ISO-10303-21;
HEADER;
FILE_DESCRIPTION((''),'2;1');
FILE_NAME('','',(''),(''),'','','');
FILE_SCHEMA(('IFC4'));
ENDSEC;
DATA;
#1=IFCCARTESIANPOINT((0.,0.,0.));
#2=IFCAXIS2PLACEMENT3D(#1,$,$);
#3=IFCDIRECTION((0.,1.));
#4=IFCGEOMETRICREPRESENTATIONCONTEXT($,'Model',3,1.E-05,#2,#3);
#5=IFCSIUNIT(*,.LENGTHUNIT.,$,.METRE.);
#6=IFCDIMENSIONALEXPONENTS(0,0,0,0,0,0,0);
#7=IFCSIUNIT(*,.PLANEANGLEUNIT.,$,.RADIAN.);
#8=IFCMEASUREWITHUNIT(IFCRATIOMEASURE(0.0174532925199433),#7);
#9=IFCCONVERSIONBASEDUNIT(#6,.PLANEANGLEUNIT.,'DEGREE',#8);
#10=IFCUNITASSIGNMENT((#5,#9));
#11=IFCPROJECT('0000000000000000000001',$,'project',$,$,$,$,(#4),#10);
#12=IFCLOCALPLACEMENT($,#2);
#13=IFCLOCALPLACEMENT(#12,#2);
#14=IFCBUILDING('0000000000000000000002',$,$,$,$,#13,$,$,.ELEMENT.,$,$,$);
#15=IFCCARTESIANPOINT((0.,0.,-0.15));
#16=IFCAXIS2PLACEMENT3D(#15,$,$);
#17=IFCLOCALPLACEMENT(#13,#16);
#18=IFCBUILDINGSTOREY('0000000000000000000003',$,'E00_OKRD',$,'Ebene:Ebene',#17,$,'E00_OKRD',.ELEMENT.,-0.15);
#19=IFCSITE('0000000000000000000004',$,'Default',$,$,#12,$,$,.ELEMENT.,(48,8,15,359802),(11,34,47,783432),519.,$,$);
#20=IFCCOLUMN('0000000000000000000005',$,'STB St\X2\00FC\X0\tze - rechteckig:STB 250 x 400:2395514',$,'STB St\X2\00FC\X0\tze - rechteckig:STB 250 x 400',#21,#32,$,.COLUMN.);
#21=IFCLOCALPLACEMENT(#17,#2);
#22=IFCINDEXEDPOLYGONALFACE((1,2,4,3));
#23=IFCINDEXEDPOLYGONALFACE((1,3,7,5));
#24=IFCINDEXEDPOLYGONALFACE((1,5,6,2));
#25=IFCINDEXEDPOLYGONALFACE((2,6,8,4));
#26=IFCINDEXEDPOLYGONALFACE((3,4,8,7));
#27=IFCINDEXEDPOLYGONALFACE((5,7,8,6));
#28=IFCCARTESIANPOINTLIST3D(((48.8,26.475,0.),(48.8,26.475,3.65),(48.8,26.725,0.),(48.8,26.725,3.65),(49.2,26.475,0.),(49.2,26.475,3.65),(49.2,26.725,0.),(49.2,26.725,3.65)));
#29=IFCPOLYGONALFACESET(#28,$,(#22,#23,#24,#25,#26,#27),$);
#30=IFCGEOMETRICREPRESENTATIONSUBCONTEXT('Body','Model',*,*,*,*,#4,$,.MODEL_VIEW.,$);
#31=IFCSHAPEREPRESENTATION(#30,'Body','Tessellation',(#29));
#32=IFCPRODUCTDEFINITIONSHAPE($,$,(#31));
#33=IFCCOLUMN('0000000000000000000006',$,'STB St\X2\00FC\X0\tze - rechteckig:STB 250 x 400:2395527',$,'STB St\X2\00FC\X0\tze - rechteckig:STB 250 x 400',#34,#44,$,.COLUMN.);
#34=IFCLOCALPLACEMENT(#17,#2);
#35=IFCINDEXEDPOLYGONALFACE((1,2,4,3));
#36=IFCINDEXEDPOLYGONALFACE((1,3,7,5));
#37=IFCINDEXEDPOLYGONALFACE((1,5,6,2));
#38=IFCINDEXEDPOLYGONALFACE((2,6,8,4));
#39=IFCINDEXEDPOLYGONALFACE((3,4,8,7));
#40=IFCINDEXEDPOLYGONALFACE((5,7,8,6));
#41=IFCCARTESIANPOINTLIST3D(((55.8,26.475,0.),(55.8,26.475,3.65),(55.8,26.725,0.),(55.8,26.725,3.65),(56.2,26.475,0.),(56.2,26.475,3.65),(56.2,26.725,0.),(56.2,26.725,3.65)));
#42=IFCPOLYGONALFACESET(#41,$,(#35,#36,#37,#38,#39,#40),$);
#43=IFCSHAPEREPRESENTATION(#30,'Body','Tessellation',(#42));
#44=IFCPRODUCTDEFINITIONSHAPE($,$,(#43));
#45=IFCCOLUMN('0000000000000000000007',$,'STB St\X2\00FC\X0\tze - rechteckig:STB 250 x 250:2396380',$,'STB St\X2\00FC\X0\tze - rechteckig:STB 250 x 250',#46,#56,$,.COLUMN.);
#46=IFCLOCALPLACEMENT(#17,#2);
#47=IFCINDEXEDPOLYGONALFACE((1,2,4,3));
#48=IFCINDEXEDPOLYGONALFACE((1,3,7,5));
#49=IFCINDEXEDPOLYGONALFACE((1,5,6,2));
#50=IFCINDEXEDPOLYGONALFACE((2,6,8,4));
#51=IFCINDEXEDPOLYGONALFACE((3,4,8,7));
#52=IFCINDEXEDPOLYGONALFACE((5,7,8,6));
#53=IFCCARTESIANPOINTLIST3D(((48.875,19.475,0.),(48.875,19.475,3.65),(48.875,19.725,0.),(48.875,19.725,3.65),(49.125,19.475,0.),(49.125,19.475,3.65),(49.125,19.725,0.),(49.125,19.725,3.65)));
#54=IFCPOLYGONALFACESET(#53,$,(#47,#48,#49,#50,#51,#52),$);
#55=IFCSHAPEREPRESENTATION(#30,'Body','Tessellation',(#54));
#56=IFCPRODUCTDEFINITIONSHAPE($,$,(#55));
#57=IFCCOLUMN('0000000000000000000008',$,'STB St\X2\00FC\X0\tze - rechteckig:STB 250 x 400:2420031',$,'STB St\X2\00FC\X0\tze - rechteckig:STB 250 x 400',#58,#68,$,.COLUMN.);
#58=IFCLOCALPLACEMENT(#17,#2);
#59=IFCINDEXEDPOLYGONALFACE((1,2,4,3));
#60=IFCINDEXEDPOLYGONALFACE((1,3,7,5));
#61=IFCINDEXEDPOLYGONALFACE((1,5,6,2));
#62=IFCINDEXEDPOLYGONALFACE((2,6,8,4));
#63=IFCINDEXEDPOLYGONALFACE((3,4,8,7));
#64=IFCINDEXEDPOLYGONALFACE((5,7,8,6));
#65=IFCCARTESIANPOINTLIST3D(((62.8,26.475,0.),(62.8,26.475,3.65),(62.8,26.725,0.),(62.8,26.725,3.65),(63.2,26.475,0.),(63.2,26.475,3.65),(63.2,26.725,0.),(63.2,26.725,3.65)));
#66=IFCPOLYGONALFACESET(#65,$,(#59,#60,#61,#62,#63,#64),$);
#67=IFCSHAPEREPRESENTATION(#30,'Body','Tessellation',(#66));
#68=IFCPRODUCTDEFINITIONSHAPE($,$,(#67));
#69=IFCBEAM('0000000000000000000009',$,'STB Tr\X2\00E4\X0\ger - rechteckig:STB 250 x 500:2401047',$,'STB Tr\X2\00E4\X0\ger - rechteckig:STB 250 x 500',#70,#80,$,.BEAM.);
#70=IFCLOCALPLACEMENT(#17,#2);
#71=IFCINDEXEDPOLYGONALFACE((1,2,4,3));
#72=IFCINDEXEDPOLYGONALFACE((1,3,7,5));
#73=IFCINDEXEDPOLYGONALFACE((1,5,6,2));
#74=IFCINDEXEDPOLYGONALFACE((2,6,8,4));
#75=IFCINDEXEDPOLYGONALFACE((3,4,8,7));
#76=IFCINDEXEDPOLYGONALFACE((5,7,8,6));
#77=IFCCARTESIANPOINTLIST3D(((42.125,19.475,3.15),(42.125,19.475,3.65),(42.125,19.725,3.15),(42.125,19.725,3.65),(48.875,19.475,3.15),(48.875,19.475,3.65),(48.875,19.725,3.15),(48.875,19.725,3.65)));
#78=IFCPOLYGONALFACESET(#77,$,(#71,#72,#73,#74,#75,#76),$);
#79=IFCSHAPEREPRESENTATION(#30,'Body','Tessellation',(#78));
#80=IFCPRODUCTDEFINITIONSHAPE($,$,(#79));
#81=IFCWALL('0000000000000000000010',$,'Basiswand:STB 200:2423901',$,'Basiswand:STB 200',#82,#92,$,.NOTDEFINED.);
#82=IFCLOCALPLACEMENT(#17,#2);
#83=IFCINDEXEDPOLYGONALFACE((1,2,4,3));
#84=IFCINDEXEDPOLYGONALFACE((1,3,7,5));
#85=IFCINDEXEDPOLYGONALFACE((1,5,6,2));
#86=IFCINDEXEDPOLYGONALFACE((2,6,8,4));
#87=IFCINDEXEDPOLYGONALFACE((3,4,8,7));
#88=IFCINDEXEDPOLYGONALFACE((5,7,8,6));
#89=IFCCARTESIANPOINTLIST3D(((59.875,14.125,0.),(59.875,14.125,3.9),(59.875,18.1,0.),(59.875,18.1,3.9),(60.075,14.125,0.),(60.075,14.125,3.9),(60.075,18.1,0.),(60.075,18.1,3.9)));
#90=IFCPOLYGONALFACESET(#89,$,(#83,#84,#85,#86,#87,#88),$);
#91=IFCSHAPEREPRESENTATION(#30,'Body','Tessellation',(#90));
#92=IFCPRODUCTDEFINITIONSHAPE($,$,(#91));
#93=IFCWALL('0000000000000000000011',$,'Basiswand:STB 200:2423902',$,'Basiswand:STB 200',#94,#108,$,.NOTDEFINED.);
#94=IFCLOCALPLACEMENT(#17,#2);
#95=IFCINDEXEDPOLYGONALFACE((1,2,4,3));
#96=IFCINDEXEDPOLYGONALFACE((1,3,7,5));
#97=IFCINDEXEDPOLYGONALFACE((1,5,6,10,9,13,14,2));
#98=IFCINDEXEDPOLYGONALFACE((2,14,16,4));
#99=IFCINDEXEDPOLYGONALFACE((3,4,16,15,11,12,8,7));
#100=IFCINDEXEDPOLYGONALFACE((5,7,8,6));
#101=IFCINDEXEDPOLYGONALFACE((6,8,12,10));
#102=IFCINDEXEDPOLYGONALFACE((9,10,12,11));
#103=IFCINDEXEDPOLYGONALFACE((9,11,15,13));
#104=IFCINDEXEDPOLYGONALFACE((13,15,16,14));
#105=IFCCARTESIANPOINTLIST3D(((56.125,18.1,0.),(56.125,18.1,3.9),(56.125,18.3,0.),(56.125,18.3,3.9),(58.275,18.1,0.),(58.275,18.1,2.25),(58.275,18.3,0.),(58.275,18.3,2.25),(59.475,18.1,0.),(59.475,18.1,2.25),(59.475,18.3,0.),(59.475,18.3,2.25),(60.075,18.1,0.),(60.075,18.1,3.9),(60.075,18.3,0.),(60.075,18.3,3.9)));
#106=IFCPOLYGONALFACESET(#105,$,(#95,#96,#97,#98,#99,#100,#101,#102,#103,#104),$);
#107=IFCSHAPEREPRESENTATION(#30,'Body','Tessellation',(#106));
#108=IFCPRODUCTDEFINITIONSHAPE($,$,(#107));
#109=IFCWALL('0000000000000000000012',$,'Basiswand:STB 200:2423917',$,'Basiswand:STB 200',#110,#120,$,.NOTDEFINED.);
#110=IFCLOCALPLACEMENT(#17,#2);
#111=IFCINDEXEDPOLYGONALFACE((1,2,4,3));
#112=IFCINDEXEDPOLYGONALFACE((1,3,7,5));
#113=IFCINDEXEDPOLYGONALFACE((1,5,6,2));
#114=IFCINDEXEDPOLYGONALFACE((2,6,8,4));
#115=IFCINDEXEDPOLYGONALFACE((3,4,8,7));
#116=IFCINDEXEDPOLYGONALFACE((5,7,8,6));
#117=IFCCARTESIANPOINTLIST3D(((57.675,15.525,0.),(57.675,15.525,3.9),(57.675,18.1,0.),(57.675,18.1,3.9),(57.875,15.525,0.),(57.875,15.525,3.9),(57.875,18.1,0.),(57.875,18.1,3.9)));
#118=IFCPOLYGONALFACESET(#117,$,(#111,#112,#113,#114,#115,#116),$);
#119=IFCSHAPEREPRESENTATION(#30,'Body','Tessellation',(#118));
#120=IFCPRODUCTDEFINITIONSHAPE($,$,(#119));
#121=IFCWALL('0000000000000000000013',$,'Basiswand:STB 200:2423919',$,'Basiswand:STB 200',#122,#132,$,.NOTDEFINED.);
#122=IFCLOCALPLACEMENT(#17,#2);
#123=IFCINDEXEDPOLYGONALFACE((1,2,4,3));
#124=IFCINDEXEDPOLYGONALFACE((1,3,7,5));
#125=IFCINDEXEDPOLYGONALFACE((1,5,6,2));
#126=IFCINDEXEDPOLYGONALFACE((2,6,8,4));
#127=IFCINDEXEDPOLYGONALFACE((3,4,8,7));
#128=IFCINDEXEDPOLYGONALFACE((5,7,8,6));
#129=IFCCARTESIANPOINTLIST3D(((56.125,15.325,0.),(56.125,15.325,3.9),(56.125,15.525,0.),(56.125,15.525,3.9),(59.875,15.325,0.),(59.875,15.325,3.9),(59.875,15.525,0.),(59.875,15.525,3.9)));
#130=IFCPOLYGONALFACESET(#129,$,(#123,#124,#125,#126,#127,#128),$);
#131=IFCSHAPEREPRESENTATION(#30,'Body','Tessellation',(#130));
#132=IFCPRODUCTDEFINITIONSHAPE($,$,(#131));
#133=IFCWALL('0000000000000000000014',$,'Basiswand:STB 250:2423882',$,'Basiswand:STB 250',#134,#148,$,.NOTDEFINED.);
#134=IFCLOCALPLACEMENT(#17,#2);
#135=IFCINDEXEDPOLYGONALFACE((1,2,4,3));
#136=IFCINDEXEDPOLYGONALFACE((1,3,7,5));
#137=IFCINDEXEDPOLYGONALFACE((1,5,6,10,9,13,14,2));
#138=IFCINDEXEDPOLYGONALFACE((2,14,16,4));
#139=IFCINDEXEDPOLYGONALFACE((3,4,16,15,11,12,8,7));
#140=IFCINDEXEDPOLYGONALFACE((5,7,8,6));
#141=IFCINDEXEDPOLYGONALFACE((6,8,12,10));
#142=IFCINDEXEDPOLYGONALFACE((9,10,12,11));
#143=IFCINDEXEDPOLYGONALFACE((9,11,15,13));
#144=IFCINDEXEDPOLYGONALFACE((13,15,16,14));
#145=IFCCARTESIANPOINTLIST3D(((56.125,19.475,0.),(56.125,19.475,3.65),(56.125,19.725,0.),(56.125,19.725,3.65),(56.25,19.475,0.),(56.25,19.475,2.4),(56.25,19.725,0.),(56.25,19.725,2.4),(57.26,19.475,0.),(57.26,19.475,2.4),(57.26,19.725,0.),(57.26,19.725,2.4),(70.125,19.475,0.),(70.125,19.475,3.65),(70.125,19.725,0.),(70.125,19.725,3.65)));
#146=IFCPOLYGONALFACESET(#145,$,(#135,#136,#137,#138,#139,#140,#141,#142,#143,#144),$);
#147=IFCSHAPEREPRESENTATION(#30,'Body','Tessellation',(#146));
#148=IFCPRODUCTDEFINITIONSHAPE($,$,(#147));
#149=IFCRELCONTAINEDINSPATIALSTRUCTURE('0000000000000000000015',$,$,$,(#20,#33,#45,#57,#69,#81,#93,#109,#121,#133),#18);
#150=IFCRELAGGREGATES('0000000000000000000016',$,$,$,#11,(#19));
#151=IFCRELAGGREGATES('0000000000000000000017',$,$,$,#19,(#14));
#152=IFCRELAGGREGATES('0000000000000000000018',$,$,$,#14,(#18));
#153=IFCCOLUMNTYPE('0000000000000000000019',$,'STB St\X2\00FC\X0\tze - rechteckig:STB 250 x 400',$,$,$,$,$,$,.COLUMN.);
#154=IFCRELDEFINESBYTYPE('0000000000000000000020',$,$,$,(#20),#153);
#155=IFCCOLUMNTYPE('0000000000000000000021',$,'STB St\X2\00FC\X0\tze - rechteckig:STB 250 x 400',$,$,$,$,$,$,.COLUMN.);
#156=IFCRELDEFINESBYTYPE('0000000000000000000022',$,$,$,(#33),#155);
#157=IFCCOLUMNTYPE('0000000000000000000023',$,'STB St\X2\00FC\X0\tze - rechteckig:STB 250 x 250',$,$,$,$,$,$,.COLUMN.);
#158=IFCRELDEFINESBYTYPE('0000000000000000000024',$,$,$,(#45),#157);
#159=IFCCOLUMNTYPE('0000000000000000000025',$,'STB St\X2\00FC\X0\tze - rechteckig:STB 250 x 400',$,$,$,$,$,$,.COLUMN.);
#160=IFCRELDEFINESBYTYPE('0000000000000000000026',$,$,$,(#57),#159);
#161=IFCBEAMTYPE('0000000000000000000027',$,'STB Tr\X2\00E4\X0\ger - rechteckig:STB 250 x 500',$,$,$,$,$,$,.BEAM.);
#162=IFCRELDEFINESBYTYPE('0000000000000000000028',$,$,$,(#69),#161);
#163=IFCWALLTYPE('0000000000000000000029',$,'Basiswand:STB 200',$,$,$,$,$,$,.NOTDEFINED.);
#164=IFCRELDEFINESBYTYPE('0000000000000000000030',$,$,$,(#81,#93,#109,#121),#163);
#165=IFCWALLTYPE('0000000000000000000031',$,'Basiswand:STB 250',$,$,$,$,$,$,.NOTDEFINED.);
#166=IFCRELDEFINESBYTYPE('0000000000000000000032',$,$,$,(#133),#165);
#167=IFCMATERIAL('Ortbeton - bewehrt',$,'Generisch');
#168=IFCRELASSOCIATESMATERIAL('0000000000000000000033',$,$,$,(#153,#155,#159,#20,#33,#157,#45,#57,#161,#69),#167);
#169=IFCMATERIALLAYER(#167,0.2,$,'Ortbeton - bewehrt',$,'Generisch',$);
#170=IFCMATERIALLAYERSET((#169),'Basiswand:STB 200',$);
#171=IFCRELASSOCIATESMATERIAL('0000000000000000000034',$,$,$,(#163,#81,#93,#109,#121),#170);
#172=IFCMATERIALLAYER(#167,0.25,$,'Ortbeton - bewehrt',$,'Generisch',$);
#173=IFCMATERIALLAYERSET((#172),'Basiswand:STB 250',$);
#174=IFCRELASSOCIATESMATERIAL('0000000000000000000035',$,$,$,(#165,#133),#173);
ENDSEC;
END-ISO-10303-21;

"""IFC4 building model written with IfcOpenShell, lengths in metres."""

from ifc_helpers import new_model, entity, si_unit, converted_unit, direction, frame, frame_2d, origin, origin_2d_with_axis, place, context, subcontext, project, spatial, rectangle, extrude, source, transform, mapped, material, layer, layer_set, layer_usage, material_profile, profile_set, profile_usage, type_object, type_shapes, element, save


model = new_model("IFC4")

# Units and contexts
model_context = context("Model", 3, precision=1e-05, world=origin(), true_north=direction((0.0, 1.0)))
body_context = subcontext(model_context, "Body", "Model", "MODEL_VIEW")
ifc_project = project(units=[si_unit("LENGTHUNIT", "METRE"), converted_unit("PLANEANGLEUNIT", "DEGREE", entity("IfcRatioMeasure", 0.0174532925199433), si_unit("PLANEANGLEUNIT", "RADIAN"), dimensions=[0, 0, 0, 0, 0, 0, 0])], contexts=[model_context])

# Site, building, storey
site_placement = place(None, frame((0.0, 0.0, 0.0)))
site = spatial("IfcSite", under=ifc_project, at=site_placement, Name="Default", CompositionType="ELEMENT", RefLatitude=(48, 8, 15, 359802), RefLongitude=(11, 34, 47, 783432), RefElevation=519.0)
building_placement = place(site_placement, origin())
building = spatial("IfcBuilding", under=site, at=building_placement, CompositionType="ELEMENT")
storey_placement = place(building_placement, frame((0.0, 0.0, -0.15)))
storey = spatial("IfcBuildingStorey", under=building, at=storey_placement, Name="E00_OKRD", ObjectType="Ebene:Ebene", LongName="E00_OKRD", CompositionType="ELEMENT", Elevation=-0.15)

# Columns
ifc_material_1 = material(Name="Ortbeton - bewehrt", Category="Generisch")
ifc_material_profile_1 = material_profile(ifc_material_1, rectangle(XDim=0.4, YDim=0.25, at=frame_2d((0.0, 0.0), x_axis=(1.0, 0.0))), Name="STB 250 x 400")
ifc_profile_set_1 = profile_set([ifc_material_profile_1], Name="STB 250 x 400")
ifc_profile_usage_1 = profile_usage(ifc_profile_set_1)
column_type_1 = type_object("IfcColumnType", Name="STB Stütze - rechteckig:STB 250 x 400", PredefinedType="COLUMN", material=ifc_profile_set_1)
shared_shape_1 = source(origin(), body_context, "Body", "SweptSolid", [
    extrude(rectangle(XDim=0.4, YDim=0.25, at=origin_2d_with_axis()), frame((0.2, 0.125, 0.0), z_axis=(0.0, 0.0, 1.0), x_axis=(-1.0, 0.0, 0.0)), (0.0, 0.0, 1.0), 3.65),
])
type_shapes(column_type_1, [shared_shape_1])
column_1_placement = place(storey_placement, frame((48.8, 26.475, 0.0)))
element("IfcColumn", 1, at=column_1_placement, inside=storey, type_object=column_type_1, material=ifc_profile_usage_1, Name="STB Stütze - rechteckig:STB 250 x 400:2395514", ObjectType="STB Stütze - rechteckig:STB 250 x 400", PredefinedType="COLUMN", context=body_context, shape_type="MappedRepresentation", body=[
    mapped(shared_shape_1, transform((0.0, 0.0, 0.0), scale=1.0)),
])
ifc_profile_usage_2 = profile_usage(ifc_profile_set_1)
column_type_2 = type_object("IfcColumnType", Name="STB Stütze - rechteckig:STB 250 x 400", PredefinedType="COLUMN", material=ifc_profile_set_1)
shared_shape_2 = source(origin(), body_context, "Body", "SweptSolid", [
    extrude(rectangle(XDim=0.4, YDim=0.25, at=frame_2d((0.0, 0.0), x_axis=(1.0, 0.0))), frame((0.2, 0.125, 0.0), z_axis=(0.0, 0.0, 1.0), x_axis=(-1.0, 0.0, 0.0)), (0.0, 0.0, 1.0), 3.65),
])
type_shapes(column_type_2, [shared_shape_2])
column_2_placement = place(storey_placement, frame((55.8, 26.475, 0.0)))
element("IfcColumn", 2, at=column_2_placement, inside=storey, type_object=column_type_2, material=ifc_profile_usage_2, Name="STB Stütze - rechteckig:STB 250 x 400:2395527", ObjectType="STB Stütze - rechteckig:STB 250 x 400", PredefinedType="COLUMN", context=body_context, shape_type="MappedRepresentation", body=[
    mapped(shared_shape_2, transform((0.0, 0.0, 0.0), scale=1.0)),
])
ifc_material_profile_2 = material_profile(ifc_material_1, rectangle(XDim=0.25, YDim=0.25, at=origin_2d_with_axis()), Name="STB 250 x 250")
ifc_profile_set_2 = profile_set([ifc_material_profile_2], Name="STB 250 x 250")
ifc_profile_usage_3 = profile_usage(ifc_profile_set_2)
column_type_3 = type_object("IfcColumnType", Name="STB Stütze - rechteckig:STB 250 x 250", PredefinedType="COLUMN", material=ifc_profile_set_2)
shared_shape_3 = source(origin(), body_context, "Body", "SweptSolid", [
    extrude(rectangle(XDim=0.25, YDim=0.25, at=frame_2d((0.0, 0.0), x_axis=(1.0, 0.0))), frame((0.125, 0.125, 0.0), z_axis=(0.0, 0.0, 1.0), x_axis=(-1.0, 0.0, 0.0)), (0.0, 0.0, 1.0), 3.65),
])
type_shapes(column_type_3, [shared_shape_3])
column_3_placement = place(storey_placement, frame((48.875, 19.475, 0.0)))
element("IfcColumn", 3, at=column_3_placement, inside=storey, type_object=column_type_3, material=ifc_profile_usage_3, Name="STB Stütze - rechteckig:STB 250 x 250:2396380", ObjectType="STB Stütze - rechteckig:STB 250 x 250", PredefinedType="COLUMN", context=body_context, shape_type="MappedRepresentation", body=[
    mapped(shared_shape_3, transform((0.0, 0.0, 0.0), scale=1.0)),
])
ifc_profile_usage_4 = profile_usage(ifc_profile_set_1)
column_type_4 = type_object("IfcColumnType", Name="STB Stütze - rechteckig:STB 250 x 400", PredefinedType="COLUMN", material=ifc_profile_set_1)
shared_shape_4 = source(origin(), body_context, "Body", "SweptSolid", [
    extrude(rectangle(XDim=0.4, YDim=0.25, at=origin_2d_with_axis()), frame((0.2, 0.125, 0.0), z_axis=(0.0, 0.0, 1.0), x_axis=(-1.0, 0.0, 0.0)), (0.0, 0.0, 1.0), 3.65),
])
type_shapes(column_type_4, [shared_shape_4])
column_4_placement = place(storey_placement, frame((62.8, 26.475, 0.0)))
element("IfcColumn", 4, at=column_4_placement, inside=storey, type_object=column_type_4, material=ifc_profile_usage_4, Name="STB Stütze - rechteckig:STB 250 x 400:2420031", ObjectType="STB Stütze - rechteckig:STB 250 x 400", PredefinedType="COLUMN", context=body_context, shape_type="MappedRepresentation", body=[
    mapped(shared_shape_4, transform((0.0, 0.0, 0.0), scale=1.0)),
])

# Beam
ifc_material_profile_3 = material_profile(ifc_material_1, rectangle(XDim=0.5, YDim=0.25, at=frame_2d((0.0, 0.0), x_axis=(1.0, 0.0))), Name="STB 250 x 500")
ifc_profile_set_3 = profile_set([ifc_material_profile_3], Name="STB 250 x 500")
ifc_profile_usage_5 = profile_usage(ifc_profile_set_3, cardinal=8)
beam_type = type_object("IfcBeamType", Name="STB Träger - rechteckig:STB 250 x 500", PredefinedType="BEAM", material=ifc_profile_set_3)
shared_shape_5 = source(origin(), body_context, "Body", "SweptSolid", [
    extrude(rectangle(XDim=0.5, YDim=0.25, at=frame_2d((0.0, 0.0), x_axis=(1.0, 0.0))), frame((0.0, 0.125, 0.25), z_axis=(1.0, 0.0, 0.0), x_axis=(0.0, 0.0, -1.0)), (0.0, 0.0, 1.0), 6.75),
])
type_shapes(beam_type, [shared_shape_5])
beam_placement = place(storey_placement, frame((42.125, 19.475, 3.15)))
element("IfcBeam", 5, at=beam_placement, inside=storey, type_object=beam_type, material=ifc_profile_usage_5, Name="STB Träger - rechteckig:STB 250 x 500:2401047", ObjectType="STB Träger - rechteckig:STB 250 x 500", PredefinedType="BEAM", context=body_context, shape_type="MappedRepresentation", body=[
    mapped(shared_shape_5, transform((0.0, 0.0, 0.0), scale=1.0)),
])

# Wall
ifc_layer_1 = layer(ifc_material_1, 0.2, Name="Ortbeton - bewehrt", Category="Generisch")
ifc_layer_set_1 = layer_set([ifc_layer_1], Name="Basiswand:STB 200")
ifc_layer_usage_1 = layer_usage(ifc_layer_set_1, "AXIS2", "NEGATIVE", 0.1)
wall_type_1 = type_object("IfcWallType", Name="Basiswand:STB 200", PredefinedType="NOTDEFINED", material=ifc_layer_set_1)
wall_1_placement = place(storey_placement, frame((59.975, 14.125, 0.0), z_axis=(0.0, 0.0, 1.0), x_axis=(0.0, 1.0, 0.0)))
element("IfcWall", 6, at=wall_1_placement, inside=storey, type_object=wall_type_1, material=ifc_layer_usage_1, Name="Basiswand:STB 200:2423901", ObjectType="Basiswand:STB 200", PredefinedType="NOTDEFINED", context=body_context, shape_type="SweptSolid", body=[
    extrude(rectangle(XDim=3.975, YDim=0.2, at=frame_2d((1.9875, 0.0), x_axis=(-1.0, 0.0))), origin(), (0.0, 0.0, 1.0), 3.9),
])

# Wall, opening
ifc_layer_usage_2 = layer_usage(ifc_layer_set_1, "AXIS2", "NEGATIVE", 0.1)
wall_2_placement = place(storey_placement, frame((60.075, 18.2, 0.0), z_axis=(0.0, 0.0, 1.0), x_axis=(-1.0, 0.0, 0.0)))
wall_2 = element("IfcWall", 7, at=wall_2_placement, inside=storey, type_object=wall_type_1, material=ifc_layer_usage_2, Name="Basiswand:STB 200:2423902", ObjectType="Basiswand:STB 200", PredefinedType="NOTDEFINED", context=body_context, shape_type="SweptSolid", body=[
    extrude(rectangle(XDim=3.95, YDim=0.2, at=frame_2d((1.975, 0.0), x_axis=(-1.0, 0.0))), origin(), (0.0, 0.0, 1.0), 3.9),
])
opening_1_placement = place(wall_2_placement, frame((1.8, 0.1, 0.0)))
element("IfcOpeningElement", 8, at=opening_1_placement, cuts=wall_2, ObjectType="Opening", PredefinedType="OPENING", context=body_context, shape_type="SweptSolid", body=[
    extrude(rectangle(XDim=2.25, YDim=1.2, at=frame_2d((1.125, 0.6), x_axis=(1.0, 0.0))), frame((0.0, 0.0, 0.0), z_axis=(0.0, -1.0, 0.0), x_axis=(0.0, 0.0, 1.0)), (0.0, 0.0, 1.0), 0.2),
])

# Walls
ifc_layer_usage_3 = layer_usage(ifc_layer_set_1, "AXIS2", "POSITIVE", -0.1)
wall_3_placement = place(storey_placement, frame((57.775, 15.525, 0.0), z_axis=(0.0, 0.0, 1.0), x_axis=(0.0, 1.0, 0.0)))
element("IfcWall", 9, at=wall_3_placement, inside=storey, type_object=wall_type_1, material=ifc_layer_usage_3, Name="Basiswand:STB 200:2423917", ObjectType="Basiswand:STB 200", PredefinedType="NOTDEFINED", context=body_context, shape_type="SweptSolid", body=[
    extrude(rectangle(XDim=2.575, YDim=0.2, at=frame_2d((1.2875, 0.0), x_axis=(-1.0, 0.0))), origin(), (0.0, 0.0, 1.0), 3.9),
])
ifc_layer_usage_4 = layer_usage(ifc_layer_set_1, "AXIS2", "NEGATIVE", 0.1)
wall_4_placement = place(storey_placement, frame((59.875, 15.425, 0.0), z_axis=(0.0, 0.0, 1.0), x_axis=(-1.0, 0.0, 0.0)))
element("IfcWall", 10, at=wall_4_placement, inside=storey, type_object=wall_type_1, material=ifc_layer_usage_4, Name="Basiswand:STB 200:2423919", ObjectType="Basiswand:STB 200", PredefinedType="NOTDEFINED", context=body_context, shape_type="SweptSolid", body=[
    extrude(rectangle(XDim=3.75, YDim=0.2, at=frame_2d((1.875, 0.0), x_axis=(-1.0, 0.0))), origin(), (0.0, 0.0, 1.0), 3.9),
])

# Wall, opening
ifc_layer_2 = layer(ifc_material_1, 0.25, Name="Ortbeton - bewehrt", Category="Generisch")
ifc_layer_set_2 = layer_set([ifc_layer_2], Name="Basiswand:STB 250")
wall_type_2 = type_object("IfcWallType", Name="Basiswand:STB 250", PredefinedType="NOTDEFINED", material=ifc_layer_set_2)
ifc_layer_usage_5 = layer_usage(ifc_layer_set_2, "AXIS2", "NEGATIVE", 0.125)
wall_5_placement = place(storey_placement, frame((56.125, 19.6, 0.0)))
wall_5 = element("IfcWall", 11, at=wall_5_placement, inside=storey, type_object=wall_type_2, material=ifc_layer_usage_5, Name="Basiswand:STB 250:2423882", ObjectType="Basiswand:STB 250", PredefinedType="NOTDEFINED", context=body_context, shape_type="SweptSolid", body=[
    extrude(rectangle(XDim=14.0, YDim=0.25, at=frame_2d((7.0, 0.0), x_axis=(-1.0, 0.0))), origin(), (0.0, 0.0, 1.0), 3.65),
])
opening_2_placement = place(wall_5_placement, frame((0.125, -0.125, 0.0)))
element("IfcOpeningElement", 12, at=opening_2_placement, cuts=wall_5, ObjectType="Opening", PredefinedType="OPENING", context=body_context, shape_type="SweptSolid", body=[
    extrude(rectangle(XDim=2.4, YDim=1.01, at=frame_2d((0.0, 0.0), x_axis=(0.0, 1.0))), frame((0.505, 0.0, 1.2), z_axis=(0.0, 1.0, 0.0), x_axis=(1.0, 0.0, 0.0)), (0.0, 0.0, 1.0), 0.25),
    extrude(rectangle(XDim=2.27, YDim=0.95, at=frame_2d((0.0, 0.0), x_axis=(1.0, 0.0))), frame((0.505, 0.295, 1.235), z_axis=(0.0, 1.0, 0.0), x_axis=(0.0, 0.0, -1.0)), (0.0, 0.0, 1.0), 0.255),
])

save(model, "model.ifc")
